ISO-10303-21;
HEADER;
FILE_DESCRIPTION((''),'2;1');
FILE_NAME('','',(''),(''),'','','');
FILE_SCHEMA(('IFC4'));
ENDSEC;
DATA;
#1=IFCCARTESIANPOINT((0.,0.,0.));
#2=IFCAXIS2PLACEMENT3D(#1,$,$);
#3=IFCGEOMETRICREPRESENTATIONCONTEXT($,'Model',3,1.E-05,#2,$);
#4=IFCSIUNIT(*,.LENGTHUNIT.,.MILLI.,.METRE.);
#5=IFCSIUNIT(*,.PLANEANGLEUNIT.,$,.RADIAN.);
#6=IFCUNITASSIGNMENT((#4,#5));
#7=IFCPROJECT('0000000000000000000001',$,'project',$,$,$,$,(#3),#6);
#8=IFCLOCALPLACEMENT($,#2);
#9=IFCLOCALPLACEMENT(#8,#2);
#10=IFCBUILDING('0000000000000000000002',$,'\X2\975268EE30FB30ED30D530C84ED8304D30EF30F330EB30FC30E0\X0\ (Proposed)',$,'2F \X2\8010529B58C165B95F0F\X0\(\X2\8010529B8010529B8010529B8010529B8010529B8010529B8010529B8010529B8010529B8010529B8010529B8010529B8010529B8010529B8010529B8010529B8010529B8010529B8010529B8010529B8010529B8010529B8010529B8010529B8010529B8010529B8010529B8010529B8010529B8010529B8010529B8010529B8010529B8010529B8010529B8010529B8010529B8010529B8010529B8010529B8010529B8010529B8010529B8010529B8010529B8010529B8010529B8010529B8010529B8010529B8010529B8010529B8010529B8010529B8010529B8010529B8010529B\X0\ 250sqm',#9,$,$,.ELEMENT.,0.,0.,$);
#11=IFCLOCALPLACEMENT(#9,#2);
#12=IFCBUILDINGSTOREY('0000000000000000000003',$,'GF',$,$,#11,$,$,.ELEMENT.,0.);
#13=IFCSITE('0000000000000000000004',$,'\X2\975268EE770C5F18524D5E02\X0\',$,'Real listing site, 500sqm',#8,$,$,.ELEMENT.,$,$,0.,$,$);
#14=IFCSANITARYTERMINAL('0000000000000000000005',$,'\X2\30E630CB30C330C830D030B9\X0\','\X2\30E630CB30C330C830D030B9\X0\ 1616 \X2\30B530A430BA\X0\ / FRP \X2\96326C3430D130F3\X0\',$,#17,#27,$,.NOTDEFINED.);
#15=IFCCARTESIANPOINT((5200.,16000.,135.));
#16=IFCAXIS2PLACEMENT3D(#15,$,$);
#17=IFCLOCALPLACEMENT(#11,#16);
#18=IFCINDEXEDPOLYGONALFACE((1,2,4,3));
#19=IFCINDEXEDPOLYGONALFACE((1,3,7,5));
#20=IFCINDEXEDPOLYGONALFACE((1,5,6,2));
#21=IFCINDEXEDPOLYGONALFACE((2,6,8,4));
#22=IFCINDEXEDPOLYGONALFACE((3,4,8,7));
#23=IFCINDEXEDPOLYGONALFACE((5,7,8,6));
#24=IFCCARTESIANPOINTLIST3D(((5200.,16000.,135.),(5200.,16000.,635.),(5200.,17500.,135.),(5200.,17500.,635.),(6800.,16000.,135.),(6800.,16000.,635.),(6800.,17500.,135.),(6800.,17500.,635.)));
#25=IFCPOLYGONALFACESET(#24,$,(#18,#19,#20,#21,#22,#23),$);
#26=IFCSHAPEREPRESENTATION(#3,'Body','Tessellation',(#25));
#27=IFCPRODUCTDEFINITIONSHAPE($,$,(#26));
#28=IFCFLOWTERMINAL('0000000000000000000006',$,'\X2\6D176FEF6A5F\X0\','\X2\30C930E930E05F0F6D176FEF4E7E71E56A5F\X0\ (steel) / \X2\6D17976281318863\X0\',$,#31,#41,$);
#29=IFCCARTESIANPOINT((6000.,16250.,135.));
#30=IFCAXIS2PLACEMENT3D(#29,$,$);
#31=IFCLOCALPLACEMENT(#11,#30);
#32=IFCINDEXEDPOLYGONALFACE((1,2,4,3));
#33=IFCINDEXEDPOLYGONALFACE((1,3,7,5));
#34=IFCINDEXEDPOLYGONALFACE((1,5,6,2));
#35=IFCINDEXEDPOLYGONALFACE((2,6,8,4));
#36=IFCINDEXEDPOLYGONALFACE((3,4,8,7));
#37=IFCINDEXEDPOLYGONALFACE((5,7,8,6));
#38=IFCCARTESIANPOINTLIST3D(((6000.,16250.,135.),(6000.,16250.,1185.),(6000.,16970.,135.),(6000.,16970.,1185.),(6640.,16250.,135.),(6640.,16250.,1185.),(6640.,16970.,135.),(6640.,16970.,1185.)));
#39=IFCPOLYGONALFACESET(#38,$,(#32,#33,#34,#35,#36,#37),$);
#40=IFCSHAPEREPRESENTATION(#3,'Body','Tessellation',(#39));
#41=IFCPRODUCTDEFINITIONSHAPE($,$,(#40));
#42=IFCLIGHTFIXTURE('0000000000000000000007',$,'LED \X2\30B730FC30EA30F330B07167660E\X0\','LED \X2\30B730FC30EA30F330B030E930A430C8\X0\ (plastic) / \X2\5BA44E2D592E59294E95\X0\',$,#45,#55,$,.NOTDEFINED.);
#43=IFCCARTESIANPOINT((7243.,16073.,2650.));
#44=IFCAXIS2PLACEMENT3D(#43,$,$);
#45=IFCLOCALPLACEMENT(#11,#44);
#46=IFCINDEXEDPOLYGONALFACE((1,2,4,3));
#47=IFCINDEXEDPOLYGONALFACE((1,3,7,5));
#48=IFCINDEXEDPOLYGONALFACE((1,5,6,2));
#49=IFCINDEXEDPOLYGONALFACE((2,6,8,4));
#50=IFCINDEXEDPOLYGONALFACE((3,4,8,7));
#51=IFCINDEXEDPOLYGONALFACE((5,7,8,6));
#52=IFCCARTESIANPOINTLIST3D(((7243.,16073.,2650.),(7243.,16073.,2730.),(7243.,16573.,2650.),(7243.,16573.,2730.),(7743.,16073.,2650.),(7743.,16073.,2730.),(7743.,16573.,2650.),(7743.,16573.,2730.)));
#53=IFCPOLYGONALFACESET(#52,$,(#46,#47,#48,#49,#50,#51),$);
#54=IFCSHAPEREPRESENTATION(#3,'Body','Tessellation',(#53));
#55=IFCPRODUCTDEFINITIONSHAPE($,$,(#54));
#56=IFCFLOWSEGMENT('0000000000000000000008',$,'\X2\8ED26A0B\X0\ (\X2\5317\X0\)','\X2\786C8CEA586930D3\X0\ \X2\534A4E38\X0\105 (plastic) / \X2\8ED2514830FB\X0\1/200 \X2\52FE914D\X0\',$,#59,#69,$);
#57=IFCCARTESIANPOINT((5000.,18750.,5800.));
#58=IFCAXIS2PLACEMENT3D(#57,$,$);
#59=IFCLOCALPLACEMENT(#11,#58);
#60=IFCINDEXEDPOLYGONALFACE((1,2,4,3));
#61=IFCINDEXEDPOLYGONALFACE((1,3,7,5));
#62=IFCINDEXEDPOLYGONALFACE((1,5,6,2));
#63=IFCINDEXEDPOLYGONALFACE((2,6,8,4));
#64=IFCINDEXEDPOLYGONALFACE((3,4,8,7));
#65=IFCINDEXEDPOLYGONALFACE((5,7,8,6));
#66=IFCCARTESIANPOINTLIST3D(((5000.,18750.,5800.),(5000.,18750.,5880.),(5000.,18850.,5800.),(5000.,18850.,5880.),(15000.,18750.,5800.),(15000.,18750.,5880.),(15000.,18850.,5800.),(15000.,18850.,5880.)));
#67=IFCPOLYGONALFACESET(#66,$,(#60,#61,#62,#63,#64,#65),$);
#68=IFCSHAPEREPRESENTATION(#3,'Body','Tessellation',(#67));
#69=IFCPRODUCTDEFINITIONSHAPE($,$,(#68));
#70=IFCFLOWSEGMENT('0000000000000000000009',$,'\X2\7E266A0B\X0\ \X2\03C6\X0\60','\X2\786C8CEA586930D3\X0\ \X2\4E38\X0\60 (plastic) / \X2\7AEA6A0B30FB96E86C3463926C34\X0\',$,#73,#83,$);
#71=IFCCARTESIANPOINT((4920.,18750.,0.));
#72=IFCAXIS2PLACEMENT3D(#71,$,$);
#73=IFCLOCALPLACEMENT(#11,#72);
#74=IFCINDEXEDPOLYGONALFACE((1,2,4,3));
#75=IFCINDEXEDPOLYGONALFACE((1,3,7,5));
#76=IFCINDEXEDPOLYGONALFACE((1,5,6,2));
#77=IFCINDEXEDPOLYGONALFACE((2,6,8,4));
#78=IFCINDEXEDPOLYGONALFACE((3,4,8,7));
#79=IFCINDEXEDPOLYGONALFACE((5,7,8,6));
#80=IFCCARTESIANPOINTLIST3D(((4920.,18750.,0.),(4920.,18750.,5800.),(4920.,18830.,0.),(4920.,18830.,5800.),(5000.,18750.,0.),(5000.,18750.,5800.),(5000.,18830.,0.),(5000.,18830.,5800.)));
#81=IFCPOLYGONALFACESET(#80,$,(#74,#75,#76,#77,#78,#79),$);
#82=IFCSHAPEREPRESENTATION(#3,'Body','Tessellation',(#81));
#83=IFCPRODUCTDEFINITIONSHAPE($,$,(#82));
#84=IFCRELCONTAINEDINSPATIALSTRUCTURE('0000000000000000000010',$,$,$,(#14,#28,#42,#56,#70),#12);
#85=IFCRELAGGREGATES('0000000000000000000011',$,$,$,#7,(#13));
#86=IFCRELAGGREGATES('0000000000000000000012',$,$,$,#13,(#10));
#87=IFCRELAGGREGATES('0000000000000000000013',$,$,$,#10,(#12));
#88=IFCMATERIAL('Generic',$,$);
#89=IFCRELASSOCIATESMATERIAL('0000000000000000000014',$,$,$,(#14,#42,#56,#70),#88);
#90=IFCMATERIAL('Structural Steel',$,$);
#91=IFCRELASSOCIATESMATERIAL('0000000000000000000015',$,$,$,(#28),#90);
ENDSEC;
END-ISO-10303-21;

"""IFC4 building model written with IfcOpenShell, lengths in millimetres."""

from ifc_helpers import new_model, si_unit, frame, frame_2d, origin, place, context, project, spatial, rectangle, extrude, material, element, save


model = new_model("IFC4")

# Units and contexts
model_context = context("Model", 3, precision=1e-05, world=origin())
ifc_project = project(units=[si_unit("LENGTHUNIT", "METRE", prefix="MILLI"), si_unit("PLANEANGLEUNIT", "RADIAN")], contexts=[model_context])

# Site, building, storey
site_placement = place(None, origin())
site = spatial("IfcSite", under=ifc_project, at=site_placement, Name="青森県弘前市", ObjectType="Real listing site, 500sqm", CompositionType="ELEMENT", RefElevation=0.0)
building_placement = place(site_placement, origin())
building = spatial("IfcBuilding", under=site, at=building_placement, Name="青森・ロフト付きワンルーム (Proposed)", ObjectType="2F 耐力壁方式(耐力耐力耐力耐力耐力耐力耐力耐力耐力耐力耐力耐力耐力耐力耐力耐力耐力耐力耐力耐力耐力耐力耐力耐力耐力耐力耐力耐力耐力耐力耐力耐力耐力耐力耐力耐力耐力耐力耐力耐力耐力耐力耐力耐力耐力耐力耐力耐力耐力耐力耐力耐力耐力耐力耐力耐力耐力 250sqm", CompositionType="ELEMENT", ElevationOfRefHeight=0.0, ElevationOfTerrain=0.0)
storey_placement = place(building_placement, origin())
storey = spatial("IfcBuildingStorey", under=building, at=storey_placement, Name="GF", CompositionType="ELEMENT", Elevation=0.0)

# Sanitary terminal
ifc_material_1 = material(Name="Generic")
sanitary_terminal_placement = place(storey_placement, frame((5200.0, 16000.0, 135.0)))
element("IfcSanitaryTerminal", 1, at=sanitary_terminal_placement, inside=storey, material=ifc_material_1, Name="ユニットバス", Description="ユニットバス 1616 サイズ / FRP 防水パン", PredefinedType="NOTDEFINED", context=model_context, shape_type="SweptSolid", body=[
    extrude(rectangle(XDim=1600.0, YDim=1500.0, at=frame_2d((800.0, 750.0))), frame((5200.0, 16000.0, 135.0)), (0.0, 0.0, 1.0), 500.0),
])

# Flow terminal
ifc_material_2 = material(Name="Structural Steel")
flow_terminal_placement = place(storey_placement, frame((6000.0, 16250.0, 135.0)))
element("IfcFlowTerminal", 2, at=flow_terminal_placement, inside=storey, material=ifc_material_2, Name="洗濯機", Description="ドラム式洗濯乾燥機 (steel) / 洗面脱衣", context=model_context, shape_type="SweptSolid", body=[
    extrude(rectangle(XDim=640.0, YDim=720.0, at=frame_2d((320.0, 360.0))), frame((6000.0, 16250.0, 135.0)), (0.0, 0.0, 1.0), 1050.0),
])

# Light fixture
light_fixture_placement = place(storey_placement, frame((7243.0, 16073.0, 2650.0)))
element("IfcLightFixture", 3, at=light_fixture_placement, inside=storey, material=ifc_material_1, Name="LED シーリング照明", Description="LED シーリングライト (plastic) / 室中央天井", PredefinedType="NOTDEFINED", context=model_context, shape_type="SweptSolid", body=[
    extrude(rectangle(XDim=500.0, YDim=500.0, at=frame_2d((250.0, 250.0))), frame((7243.0, 16073.0, 2650.0)), (0.0, 0.0, 1.0), 80.0),
])

# Flow segments
flow_segment_1_placement = place(storey_placement, frame((5000.0, 18750.0, 5800.0)))
element("IfcFlowSegment", 4, at=flow_segment_1_placement, inside=storey, material=ifc_material_1, Name="軒樋 (北)", Description="硬質塩ビ 半丸105 (plastic) / 軒先・1/200 勾配", context=model_context, shape_type="SweptSolid", body=[
    extrude(rectangle(XDim=10000.0, YDim=100.0, at=frame_2d((5000.0, 50.0))), frame((5000.0, 18750.0, 5800.0)), (0.0, 0.0, 1.0), 80.0),
])
flow_segment_2_placement = place(storey_placement, frame((4920.0, 18750.0, 0.0)))
element("IfcFlowSegment", 5, at=flow_segment_2_placement, inside=storey, material=ifc_material_1, Name="縦樋 φ60", Description="硬質塩ビ 丸60 (plastic) / 竪樋・雨水排水", context=model_context, shape_type="SweptSolid", body=[
    extrude(rectangle(XDim=80.0, YDim=80.0, at=frame_2d((40.0, 40.0))), frame((4920.0, 18750.0, 0.0)), (0.0, 0.0, 1.0), 5800.0),
])

save(model, "model.ifc")
